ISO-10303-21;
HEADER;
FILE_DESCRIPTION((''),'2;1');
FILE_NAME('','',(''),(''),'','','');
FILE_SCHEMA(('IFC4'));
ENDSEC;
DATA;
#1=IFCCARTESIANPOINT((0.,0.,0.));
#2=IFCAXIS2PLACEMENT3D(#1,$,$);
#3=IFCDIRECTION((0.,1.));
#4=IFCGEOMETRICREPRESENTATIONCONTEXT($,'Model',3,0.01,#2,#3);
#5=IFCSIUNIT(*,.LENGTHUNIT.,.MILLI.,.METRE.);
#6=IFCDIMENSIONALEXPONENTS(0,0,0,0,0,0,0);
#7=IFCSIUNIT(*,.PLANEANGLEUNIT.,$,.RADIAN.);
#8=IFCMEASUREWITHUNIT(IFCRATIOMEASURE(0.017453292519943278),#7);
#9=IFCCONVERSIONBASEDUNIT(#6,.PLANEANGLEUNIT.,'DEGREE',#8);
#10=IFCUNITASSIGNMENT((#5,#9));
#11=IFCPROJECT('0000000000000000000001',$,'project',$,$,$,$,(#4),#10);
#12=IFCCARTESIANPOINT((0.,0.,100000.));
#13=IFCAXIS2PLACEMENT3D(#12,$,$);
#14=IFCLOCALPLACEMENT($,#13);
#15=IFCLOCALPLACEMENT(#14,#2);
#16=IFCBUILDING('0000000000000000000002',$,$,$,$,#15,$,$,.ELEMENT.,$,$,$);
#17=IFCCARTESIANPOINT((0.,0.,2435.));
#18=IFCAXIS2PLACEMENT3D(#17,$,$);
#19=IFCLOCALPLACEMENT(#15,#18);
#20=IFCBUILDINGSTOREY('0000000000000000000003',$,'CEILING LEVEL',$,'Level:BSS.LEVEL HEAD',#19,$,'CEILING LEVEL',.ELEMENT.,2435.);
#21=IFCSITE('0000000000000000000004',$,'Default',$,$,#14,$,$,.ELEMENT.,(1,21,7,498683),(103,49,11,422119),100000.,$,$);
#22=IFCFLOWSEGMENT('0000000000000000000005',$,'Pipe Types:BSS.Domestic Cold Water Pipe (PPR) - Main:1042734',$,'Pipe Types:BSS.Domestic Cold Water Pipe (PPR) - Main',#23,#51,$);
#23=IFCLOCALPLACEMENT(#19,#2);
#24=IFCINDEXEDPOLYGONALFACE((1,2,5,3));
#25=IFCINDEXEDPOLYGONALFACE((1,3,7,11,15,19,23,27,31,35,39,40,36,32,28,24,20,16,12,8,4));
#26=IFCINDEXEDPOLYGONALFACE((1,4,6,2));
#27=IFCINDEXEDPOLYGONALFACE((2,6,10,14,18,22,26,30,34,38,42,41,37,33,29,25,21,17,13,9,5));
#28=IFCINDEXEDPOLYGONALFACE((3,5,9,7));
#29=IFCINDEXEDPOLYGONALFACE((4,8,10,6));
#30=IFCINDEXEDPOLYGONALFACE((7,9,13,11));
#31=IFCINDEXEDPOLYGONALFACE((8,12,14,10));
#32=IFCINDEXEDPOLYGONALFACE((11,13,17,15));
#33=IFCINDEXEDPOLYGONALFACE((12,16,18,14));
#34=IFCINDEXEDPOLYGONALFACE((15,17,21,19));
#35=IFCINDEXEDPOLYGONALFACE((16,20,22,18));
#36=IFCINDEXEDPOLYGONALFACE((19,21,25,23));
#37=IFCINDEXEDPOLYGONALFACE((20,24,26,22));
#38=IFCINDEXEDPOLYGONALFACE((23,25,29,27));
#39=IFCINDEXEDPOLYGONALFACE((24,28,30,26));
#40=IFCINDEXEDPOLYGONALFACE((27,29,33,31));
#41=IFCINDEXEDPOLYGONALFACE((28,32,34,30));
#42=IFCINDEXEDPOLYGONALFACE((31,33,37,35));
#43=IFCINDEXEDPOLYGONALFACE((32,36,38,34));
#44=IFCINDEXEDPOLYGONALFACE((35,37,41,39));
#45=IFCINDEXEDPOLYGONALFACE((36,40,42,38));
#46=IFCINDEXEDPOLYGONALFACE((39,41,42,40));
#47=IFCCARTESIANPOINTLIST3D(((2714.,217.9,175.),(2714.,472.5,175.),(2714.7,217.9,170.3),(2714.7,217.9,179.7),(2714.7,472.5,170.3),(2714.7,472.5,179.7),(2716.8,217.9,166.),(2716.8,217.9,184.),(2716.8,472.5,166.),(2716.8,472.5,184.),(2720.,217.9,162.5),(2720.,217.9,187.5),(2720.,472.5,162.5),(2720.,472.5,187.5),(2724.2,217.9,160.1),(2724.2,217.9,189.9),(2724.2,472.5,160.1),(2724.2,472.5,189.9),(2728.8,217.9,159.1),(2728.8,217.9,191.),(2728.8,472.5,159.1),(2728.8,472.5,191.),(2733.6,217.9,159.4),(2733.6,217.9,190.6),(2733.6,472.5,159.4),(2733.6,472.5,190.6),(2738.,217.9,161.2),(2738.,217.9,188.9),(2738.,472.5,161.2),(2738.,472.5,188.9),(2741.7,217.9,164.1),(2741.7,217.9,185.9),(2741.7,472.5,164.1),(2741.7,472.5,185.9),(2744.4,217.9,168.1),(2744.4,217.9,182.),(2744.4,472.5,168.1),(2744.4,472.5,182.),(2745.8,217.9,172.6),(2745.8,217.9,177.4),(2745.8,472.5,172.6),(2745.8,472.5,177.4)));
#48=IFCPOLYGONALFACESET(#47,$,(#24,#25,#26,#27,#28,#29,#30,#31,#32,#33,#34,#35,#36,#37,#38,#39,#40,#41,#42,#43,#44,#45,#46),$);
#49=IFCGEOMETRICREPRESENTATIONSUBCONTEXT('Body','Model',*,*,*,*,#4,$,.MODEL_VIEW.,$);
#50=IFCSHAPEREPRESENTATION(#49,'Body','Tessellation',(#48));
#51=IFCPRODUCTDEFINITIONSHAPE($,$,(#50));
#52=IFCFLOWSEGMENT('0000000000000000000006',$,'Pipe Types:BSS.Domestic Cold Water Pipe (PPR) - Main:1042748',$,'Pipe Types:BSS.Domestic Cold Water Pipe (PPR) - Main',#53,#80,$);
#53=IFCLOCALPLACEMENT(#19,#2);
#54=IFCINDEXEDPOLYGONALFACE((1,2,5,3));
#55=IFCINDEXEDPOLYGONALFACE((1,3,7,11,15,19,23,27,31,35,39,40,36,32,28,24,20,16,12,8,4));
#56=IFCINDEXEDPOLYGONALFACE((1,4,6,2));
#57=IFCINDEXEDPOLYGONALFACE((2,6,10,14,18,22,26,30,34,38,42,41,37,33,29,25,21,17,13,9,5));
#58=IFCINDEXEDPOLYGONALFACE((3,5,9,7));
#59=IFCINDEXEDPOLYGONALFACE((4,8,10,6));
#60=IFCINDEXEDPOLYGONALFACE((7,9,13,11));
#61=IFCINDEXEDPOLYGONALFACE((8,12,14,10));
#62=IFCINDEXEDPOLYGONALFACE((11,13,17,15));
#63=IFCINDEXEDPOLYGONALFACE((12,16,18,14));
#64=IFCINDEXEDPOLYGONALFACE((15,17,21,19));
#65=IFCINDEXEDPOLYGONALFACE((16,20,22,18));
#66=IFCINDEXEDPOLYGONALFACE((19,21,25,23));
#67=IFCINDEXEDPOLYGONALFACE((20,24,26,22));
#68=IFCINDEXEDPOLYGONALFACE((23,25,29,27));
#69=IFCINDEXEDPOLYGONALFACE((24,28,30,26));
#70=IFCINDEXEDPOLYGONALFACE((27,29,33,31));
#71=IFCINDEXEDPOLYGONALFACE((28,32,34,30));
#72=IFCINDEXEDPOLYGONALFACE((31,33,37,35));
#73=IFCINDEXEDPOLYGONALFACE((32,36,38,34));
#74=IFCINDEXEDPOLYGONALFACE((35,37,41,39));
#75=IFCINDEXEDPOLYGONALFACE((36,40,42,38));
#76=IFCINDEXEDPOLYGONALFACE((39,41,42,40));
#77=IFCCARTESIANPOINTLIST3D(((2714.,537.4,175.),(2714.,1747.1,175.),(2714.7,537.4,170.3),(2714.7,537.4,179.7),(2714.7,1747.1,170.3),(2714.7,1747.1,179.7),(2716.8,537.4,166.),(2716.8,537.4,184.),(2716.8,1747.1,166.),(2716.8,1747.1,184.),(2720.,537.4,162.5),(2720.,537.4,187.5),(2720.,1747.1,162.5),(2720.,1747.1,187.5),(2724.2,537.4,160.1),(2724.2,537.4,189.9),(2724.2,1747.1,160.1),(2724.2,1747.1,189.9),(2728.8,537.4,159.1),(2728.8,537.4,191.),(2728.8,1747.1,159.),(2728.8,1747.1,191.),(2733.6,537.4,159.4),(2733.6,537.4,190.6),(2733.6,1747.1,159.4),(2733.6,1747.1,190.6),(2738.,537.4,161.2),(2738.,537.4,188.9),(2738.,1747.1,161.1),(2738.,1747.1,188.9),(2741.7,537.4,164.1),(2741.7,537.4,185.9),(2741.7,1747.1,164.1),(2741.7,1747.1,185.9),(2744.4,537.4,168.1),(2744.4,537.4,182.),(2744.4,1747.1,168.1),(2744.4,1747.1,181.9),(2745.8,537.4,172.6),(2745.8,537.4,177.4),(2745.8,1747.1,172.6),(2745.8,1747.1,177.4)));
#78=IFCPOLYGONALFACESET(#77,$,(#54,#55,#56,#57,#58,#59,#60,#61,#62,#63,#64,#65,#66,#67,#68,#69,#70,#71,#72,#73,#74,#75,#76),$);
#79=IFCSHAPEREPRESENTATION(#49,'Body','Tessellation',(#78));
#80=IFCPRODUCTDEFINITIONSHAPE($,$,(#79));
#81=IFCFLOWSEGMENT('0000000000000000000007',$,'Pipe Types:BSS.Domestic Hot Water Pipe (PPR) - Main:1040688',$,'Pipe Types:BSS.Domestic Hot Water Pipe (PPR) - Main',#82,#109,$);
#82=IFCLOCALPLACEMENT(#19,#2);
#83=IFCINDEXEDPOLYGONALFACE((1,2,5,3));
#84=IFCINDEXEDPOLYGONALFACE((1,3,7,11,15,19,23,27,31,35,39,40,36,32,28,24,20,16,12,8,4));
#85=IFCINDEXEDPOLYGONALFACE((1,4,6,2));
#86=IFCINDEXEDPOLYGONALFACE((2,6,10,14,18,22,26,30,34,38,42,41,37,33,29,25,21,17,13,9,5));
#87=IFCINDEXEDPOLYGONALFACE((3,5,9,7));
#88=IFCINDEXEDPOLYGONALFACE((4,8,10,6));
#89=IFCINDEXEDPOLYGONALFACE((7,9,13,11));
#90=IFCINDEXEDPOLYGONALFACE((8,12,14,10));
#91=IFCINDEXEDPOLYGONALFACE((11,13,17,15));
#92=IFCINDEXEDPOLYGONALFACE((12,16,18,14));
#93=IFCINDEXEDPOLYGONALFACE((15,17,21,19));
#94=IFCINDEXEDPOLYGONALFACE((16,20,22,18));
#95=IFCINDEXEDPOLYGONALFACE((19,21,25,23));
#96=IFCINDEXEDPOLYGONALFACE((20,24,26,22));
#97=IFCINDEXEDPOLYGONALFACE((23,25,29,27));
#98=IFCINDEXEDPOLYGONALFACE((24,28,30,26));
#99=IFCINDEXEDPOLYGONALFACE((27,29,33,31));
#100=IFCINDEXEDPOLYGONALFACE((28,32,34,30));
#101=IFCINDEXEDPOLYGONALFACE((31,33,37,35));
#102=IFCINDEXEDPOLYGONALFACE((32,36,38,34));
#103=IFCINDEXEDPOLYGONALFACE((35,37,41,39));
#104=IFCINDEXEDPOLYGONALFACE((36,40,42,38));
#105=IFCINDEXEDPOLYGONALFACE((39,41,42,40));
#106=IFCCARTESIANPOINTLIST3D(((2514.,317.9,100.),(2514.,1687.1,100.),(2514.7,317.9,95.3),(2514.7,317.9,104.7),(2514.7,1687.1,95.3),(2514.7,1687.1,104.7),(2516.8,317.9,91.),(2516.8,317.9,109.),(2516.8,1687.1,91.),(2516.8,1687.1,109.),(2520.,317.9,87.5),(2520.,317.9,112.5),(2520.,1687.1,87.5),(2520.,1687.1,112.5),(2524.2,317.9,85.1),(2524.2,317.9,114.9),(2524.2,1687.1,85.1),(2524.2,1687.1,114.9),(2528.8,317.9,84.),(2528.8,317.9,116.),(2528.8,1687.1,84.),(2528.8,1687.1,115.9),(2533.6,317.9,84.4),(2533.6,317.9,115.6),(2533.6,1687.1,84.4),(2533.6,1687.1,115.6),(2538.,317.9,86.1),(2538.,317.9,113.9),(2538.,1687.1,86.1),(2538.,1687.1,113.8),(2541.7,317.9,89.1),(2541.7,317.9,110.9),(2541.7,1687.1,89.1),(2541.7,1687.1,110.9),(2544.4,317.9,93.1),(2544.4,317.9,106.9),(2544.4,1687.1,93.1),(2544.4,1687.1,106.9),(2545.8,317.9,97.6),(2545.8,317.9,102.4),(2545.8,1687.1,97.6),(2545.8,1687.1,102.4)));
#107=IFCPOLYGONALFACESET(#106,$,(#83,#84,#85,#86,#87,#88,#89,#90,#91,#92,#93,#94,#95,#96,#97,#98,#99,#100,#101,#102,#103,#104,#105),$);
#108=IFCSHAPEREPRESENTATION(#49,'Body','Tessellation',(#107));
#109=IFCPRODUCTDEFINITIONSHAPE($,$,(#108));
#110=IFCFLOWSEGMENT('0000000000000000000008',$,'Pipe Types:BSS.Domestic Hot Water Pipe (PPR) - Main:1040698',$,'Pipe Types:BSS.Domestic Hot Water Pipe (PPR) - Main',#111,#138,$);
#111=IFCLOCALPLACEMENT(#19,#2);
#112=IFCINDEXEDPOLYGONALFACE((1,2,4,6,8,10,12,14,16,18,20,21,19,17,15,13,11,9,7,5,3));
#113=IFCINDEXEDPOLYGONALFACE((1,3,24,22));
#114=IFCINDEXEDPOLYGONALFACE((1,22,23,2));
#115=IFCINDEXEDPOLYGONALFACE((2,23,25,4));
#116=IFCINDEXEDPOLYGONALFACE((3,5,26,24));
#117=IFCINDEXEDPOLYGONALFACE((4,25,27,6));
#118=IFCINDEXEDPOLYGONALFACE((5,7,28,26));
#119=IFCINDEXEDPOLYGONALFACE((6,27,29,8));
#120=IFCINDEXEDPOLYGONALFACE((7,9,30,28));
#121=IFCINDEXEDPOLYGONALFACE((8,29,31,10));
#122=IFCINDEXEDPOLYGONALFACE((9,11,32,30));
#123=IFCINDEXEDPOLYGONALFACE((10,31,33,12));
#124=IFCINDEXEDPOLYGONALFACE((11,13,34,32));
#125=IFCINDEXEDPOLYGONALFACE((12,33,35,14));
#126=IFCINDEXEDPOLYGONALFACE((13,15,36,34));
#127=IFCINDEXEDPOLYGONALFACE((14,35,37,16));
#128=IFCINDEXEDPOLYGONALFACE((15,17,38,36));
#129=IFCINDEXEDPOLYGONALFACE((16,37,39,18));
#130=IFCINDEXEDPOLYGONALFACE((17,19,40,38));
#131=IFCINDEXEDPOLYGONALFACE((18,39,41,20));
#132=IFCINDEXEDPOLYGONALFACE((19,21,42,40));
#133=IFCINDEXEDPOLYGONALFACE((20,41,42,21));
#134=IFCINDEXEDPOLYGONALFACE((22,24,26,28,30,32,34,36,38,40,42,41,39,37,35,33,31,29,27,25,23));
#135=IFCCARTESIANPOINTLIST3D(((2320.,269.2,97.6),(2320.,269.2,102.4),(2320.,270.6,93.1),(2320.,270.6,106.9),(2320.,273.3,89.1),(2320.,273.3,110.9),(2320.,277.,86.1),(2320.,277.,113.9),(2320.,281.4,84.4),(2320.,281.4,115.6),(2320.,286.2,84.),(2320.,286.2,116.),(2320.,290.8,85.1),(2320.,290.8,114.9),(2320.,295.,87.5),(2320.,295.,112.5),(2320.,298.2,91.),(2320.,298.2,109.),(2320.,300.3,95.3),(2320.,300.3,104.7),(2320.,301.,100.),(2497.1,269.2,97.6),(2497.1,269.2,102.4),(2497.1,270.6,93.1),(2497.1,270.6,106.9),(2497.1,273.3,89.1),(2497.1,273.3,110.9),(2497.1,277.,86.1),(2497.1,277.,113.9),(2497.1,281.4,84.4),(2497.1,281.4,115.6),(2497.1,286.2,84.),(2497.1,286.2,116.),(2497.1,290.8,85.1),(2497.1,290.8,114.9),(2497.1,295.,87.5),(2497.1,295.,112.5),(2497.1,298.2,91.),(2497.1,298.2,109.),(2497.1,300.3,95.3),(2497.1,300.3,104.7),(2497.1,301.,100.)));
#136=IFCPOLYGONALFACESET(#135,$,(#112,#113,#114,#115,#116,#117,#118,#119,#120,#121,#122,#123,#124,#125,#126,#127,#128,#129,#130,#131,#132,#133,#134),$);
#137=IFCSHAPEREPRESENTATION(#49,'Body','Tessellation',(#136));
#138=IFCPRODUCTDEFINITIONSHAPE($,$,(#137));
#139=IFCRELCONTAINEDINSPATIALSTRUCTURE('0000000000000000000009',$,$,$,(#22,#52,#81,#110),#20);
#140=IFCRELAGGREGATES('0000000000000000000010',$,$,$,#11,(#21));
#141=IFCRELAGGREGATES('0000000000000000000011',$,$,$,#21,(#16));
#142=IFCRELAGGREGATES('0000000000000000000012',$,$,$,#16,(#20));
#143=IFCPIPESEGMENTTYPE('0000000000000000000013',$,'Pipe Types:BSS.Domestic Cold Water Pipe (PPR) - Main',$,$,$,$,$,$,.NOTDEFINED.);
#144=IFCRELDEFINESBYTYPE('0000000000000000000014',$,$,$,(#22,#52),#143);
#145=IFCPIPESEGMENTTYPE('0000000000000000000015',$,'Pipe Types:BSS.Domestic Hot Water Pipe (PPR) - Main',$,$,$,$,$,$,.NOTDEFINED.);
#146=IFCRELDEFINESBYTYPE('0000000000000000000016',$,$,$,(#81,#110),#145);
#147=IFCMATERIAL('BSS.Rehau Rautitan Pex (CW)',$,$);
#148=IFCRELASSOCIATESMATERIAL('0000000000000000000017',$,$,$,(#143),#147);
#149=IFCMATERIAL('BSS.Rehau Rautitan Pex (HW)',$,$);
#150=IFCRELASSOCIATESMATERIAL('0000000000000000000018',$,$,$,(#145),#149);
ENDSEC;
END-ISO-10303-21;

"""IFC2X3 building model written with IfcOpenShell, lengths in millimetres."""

from ifc_helpers import new_model, entity, si_unit, converted_unit, direction, frame, frame_2d, origin, origin_2d_with_axis, place, context, subcontext, project, spatial, circle, extrude, material, type_object, element, save


model = new_model("IFC2X3")

# Units and contexts
model_context = context("Model", 3, precision=0.01, world=origin(), true_north=direction((0.0, 1.0)))
body_context = subcontext(model_context, "Body", "Model", "MODEL_VIEW")
ifc_project = project(units=[si_unit("LENGTHUNIT", "METRE", prefix="MILLI"), converted_unit("PLANEANGLEUNIT", "DEGREE", entity("IfcRatioMeasure", 0.017453292519943278), si_unit("PLANEANGLEUNIT", "RADIAN"), dimensions=[0, 0, 0, 0, 0, 0, 0])], contexts=[model_context])

# Site, building, storey
site_placement = place(None, frame((0.0, 0.0, 100000.0)))
site = spatial("IfcSite", under=ifc_project, at=site_placement, Name="Default", CompositionType="ELEMENT", RefLatitude=(1, 21, 7, 498683), RefLongitude=(103, 49, 11, 422119), RefElevation=100000.0)
building_placement = place(site_placement, origin())
building = spatial("IfcBuilding", under=site, at=building_placement, CompositionType="ELEMENT")
storey_placement = place(building_placement, frame((0.0, 0.0, 2435.0)))
storey = spatial("IfcBuildingStorey", under=building, at=storey_placement, Name="CEILING LEVEL", ObjectType="Level:BSS.LEVEL HEAD", LongName="CEILING LEVEL", CompositionType="ELEMENT", Elevation=2435.0)

# Flow segments
ifc_material_1 = material(Name="BSS.Rehau Rautitan Pex (HW)")
ifc_material_2 = material(Name="BSS.Rehau Rautitan Pex (CW)")
pipe_segment_type_1 = type_object("IfcPipeSegmentType", Name="Pipe Types:BSS.Domestic Cold Water Pipe (PPR) - Main", PredefinedType="NOTDEFINED", material=ifc_material_2)
flow_segment_1_placement = place(storey_placement, origin())
element("IfcFlowSegment", 1, at=flow_segment_1_placement, inside=storey, type_object=pipe_segment_type_1, Name="Pipe Types:BSS.Domestic Cold Water Pipe (PPR) - Main:1042734", ObjectType="Pipe Types:BSS.Domestic Cold Water Pipe (PPR) - Main", context=body_context, shape_type="SweptSolid", body=[
    extrude(circle(Radius=16.0, at=origin_2d_with_axis()), frame((2730.0, 472.5, 175.0), z_axis=(0.0, -1.0, 0.000032), x_axis=(-1.0, 0.0, 0.0)), (0.0, 0.0, 1.0), 254.7),
])
flow_segment_2_placement = place(storey_placement, origin())
element("IfcFlowSegment", 2, at=flow_segment_2_placement, inside=storey, type_object=pipe_segment_type_1, Name="Pipe Types:BSS.Domestic Cold Water Pipe (PPR) - Main:1042748", ObjectType="Pipe Types:BSS.Domestic Cold Water Pipe (PPR) - Main", context=body_context, shape_type="SweptSolid", body=[
    extrude(circle(Radius=16.0, at=frame_2d((0.0, 0.0), x_axis=(1.0, 0.0))), frame((2730.0, 537.4, 175.0), z_axis=(0.0, 1.0, -0.000008), x_axis=(-1.0, 0.0, 0.0)), (0.0, 0.0, 1.0), 1209.7),
])
pipe_segment_type_2 = type_object("IfcPipeSegmentType", Name="Pipe Types:BSS.Domestic Hot Water Pipe (PPR) - Main", PredefinedType="NOTDEFINED", material=ifc_material_1)
flow_segment_3_placement = place(storey_placement, origin())
element("IfcFlowSegment", 3, at=flow_segment_3_placement, inside=storey, type_object=pipe_segment_type_2, Name="Pipe Types:BSS.Domestic Hot Water Pipe (PPR) - Main:1040688", ObjectType="Pipe Types:BSS.Domestic Hot Water Pipe (PPR) - Main", context=body_context, shape_type="SweptSolid", body=[
    extrude(circle(Radius=16.0, at=origin_2d_with_axis()), frame((2530.0, 317.9, 100.0), z_axis=(0.0, 1.0, -0.000003), x_axis=(-1.0, 0.0, 0.0)), (0.0, 0.0, 1.0), 1369.3),
])
flow_segment_4_placement = place(storey_placement, origin())
element("IfcFlowSegment", 4, at=flow_segment_4_placement, inside=storey, type_object=pipe_segment_type_2, Name="Pipe Types:BSS.Domestic Hot Water Pipe (PPR) - Main:1040698", ObjectType="Pipe Types:BSS.Domestic Hot Water Pipe (PPR) - Main", context=body_context, shape_type="SweptSolid", body=[
    extrude(circle(Radius=16.0, at=origin_2d_with_axis()), frame((2320.0, 285.0, 100.0), z_axis=(1.0, 0.0, 0.0), x_axis=(0.0, 1.0, 0.0)), (0.0, 0.0, 1.0), 177.1),
])

save(model, "model.ifc")
